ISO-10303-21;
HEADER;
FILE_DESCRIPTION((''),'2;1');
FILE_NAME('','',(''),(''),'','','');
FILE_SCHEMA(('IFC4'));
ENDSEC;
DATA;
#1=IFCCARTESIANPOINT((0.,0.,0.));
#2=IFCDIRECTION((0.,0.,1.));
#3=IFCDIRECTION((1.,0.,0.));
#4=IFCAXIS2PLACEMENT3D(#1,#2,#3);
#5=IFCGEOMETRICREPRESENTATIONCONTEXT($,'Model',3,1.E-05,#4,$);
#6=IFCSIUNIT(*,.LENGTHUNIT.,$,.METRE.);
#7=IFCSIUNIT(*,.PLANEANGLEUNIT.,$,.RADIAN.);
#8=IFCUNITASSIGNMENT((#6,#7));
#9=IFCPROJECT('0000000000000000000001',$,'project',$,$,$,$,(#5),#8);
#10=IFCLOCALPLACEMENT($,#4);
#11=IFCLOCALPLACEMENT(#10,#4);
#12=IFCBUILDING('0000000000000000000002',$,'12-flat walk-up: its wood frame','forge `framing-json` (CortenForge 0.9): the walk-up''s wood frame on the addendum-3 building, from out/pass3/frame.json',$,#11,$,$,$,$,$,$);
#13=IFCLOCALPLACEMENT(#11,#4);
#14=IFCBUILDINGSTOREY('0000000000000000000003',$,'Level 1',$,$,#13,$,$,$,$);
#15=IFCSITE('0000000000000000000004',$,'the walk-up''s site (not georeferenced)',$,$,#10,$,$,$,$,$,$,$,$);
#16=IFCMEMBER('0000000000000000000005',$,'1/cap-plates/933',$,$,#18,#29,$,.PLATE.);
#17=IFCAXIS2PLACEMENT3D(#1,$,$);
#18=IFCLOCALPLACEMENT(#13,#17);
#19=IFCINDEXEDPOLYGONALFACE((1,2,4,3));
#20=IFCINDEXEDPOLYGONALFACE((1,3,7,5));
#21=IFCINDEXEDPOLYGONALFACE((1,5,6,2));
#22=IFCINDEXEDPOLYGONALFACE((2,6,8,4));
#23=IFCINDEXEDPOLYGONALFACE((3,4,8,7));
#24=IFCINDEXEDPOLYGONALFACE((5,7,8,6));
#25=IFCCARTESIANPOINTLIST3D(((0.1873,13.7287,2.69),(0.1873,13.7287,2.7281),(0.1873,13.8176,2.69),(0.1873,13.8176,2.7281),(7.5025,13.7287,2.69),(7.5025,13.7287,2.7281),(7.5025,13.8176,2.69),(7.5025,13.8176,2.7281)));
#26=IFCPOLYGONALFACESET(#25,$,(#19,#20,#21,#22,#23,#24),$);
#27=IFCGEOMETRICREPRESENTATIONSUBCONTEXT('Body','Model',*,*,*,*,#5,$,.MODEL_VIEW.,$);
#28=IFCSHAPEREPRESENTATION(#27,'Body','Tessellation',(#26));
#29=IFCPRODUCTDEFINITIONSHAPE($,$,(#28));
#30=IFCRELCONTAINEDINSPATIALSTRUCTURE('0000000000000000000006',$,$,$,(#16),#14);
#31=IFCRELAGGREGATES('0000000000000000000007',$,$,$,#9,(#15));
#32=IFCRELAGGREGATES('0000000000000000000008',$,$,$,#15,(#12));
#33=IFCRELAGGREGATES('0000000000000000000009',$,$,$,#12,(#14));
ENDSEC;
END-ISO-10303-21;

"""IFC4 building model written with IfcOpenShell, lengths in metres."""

from ifc_helpers import new_model, si_unit, frame, frame_2d, origin, origin_with_axes, place, context, subcontext, project, spatial, rectangle, extrude, element, save


model = new_model("IFC4")

# Units and contexts
model_context = context("Model", 3, precision=1e-05, world=origin_with_axes())
body_context = subcontext(model_context, "Body", "Model", "MODEL_VIEW")
ifc_project = project(units=[si_unit("LENGTHUNIT", "METRE"), si_unit("PLANEANGLEUNIT", "RADIAN")], contexts=[model_context])

# Site, building, storey
site_placement = place(None, origin_with_axes())
site = spatial("IfcSite", under=ifc_project, at=site_placement, Name="the walk-up's site (not georeferenced)")
building_placement = place(site_placement, origin_with_axes())
building = spatial("IfcBuilding", under=site, at=building_placement, Name="12-flat walk-up: its wood frame", Description="forge `framing-json` (CortenForge 0.9): the walk-up's wood frame on the addendum-3 building, from out/pass3/frame.json")
storey_placement = place(building_placement, origin_with_axes())
storey = spatial("IfcBuildingStorey", under=building, at=storey_placement, Name="Level 1")

# Member
member_1_placement = place(storey_placement, frame((0.1873, 13.7287, 2.69), z_axis=(0.0, 0.0, 1.0), x_axis=(1.0, 0.0, 0.0)))
element("IfcMember", 1, at=member_1_placement, inside=storey, Name="1/cap-plates/933", PredefinedType="PLATE", context=body_context, shape_type="SweptSolid", body=[
    extrude(rectangle(XDim=7.3152, YDim=0.0889, at=frame_2d((3.6576, 0.0445))), origin(), (0.0, 0.0, 1.0), 0.0381),
])

save(model, "model.ifc")
